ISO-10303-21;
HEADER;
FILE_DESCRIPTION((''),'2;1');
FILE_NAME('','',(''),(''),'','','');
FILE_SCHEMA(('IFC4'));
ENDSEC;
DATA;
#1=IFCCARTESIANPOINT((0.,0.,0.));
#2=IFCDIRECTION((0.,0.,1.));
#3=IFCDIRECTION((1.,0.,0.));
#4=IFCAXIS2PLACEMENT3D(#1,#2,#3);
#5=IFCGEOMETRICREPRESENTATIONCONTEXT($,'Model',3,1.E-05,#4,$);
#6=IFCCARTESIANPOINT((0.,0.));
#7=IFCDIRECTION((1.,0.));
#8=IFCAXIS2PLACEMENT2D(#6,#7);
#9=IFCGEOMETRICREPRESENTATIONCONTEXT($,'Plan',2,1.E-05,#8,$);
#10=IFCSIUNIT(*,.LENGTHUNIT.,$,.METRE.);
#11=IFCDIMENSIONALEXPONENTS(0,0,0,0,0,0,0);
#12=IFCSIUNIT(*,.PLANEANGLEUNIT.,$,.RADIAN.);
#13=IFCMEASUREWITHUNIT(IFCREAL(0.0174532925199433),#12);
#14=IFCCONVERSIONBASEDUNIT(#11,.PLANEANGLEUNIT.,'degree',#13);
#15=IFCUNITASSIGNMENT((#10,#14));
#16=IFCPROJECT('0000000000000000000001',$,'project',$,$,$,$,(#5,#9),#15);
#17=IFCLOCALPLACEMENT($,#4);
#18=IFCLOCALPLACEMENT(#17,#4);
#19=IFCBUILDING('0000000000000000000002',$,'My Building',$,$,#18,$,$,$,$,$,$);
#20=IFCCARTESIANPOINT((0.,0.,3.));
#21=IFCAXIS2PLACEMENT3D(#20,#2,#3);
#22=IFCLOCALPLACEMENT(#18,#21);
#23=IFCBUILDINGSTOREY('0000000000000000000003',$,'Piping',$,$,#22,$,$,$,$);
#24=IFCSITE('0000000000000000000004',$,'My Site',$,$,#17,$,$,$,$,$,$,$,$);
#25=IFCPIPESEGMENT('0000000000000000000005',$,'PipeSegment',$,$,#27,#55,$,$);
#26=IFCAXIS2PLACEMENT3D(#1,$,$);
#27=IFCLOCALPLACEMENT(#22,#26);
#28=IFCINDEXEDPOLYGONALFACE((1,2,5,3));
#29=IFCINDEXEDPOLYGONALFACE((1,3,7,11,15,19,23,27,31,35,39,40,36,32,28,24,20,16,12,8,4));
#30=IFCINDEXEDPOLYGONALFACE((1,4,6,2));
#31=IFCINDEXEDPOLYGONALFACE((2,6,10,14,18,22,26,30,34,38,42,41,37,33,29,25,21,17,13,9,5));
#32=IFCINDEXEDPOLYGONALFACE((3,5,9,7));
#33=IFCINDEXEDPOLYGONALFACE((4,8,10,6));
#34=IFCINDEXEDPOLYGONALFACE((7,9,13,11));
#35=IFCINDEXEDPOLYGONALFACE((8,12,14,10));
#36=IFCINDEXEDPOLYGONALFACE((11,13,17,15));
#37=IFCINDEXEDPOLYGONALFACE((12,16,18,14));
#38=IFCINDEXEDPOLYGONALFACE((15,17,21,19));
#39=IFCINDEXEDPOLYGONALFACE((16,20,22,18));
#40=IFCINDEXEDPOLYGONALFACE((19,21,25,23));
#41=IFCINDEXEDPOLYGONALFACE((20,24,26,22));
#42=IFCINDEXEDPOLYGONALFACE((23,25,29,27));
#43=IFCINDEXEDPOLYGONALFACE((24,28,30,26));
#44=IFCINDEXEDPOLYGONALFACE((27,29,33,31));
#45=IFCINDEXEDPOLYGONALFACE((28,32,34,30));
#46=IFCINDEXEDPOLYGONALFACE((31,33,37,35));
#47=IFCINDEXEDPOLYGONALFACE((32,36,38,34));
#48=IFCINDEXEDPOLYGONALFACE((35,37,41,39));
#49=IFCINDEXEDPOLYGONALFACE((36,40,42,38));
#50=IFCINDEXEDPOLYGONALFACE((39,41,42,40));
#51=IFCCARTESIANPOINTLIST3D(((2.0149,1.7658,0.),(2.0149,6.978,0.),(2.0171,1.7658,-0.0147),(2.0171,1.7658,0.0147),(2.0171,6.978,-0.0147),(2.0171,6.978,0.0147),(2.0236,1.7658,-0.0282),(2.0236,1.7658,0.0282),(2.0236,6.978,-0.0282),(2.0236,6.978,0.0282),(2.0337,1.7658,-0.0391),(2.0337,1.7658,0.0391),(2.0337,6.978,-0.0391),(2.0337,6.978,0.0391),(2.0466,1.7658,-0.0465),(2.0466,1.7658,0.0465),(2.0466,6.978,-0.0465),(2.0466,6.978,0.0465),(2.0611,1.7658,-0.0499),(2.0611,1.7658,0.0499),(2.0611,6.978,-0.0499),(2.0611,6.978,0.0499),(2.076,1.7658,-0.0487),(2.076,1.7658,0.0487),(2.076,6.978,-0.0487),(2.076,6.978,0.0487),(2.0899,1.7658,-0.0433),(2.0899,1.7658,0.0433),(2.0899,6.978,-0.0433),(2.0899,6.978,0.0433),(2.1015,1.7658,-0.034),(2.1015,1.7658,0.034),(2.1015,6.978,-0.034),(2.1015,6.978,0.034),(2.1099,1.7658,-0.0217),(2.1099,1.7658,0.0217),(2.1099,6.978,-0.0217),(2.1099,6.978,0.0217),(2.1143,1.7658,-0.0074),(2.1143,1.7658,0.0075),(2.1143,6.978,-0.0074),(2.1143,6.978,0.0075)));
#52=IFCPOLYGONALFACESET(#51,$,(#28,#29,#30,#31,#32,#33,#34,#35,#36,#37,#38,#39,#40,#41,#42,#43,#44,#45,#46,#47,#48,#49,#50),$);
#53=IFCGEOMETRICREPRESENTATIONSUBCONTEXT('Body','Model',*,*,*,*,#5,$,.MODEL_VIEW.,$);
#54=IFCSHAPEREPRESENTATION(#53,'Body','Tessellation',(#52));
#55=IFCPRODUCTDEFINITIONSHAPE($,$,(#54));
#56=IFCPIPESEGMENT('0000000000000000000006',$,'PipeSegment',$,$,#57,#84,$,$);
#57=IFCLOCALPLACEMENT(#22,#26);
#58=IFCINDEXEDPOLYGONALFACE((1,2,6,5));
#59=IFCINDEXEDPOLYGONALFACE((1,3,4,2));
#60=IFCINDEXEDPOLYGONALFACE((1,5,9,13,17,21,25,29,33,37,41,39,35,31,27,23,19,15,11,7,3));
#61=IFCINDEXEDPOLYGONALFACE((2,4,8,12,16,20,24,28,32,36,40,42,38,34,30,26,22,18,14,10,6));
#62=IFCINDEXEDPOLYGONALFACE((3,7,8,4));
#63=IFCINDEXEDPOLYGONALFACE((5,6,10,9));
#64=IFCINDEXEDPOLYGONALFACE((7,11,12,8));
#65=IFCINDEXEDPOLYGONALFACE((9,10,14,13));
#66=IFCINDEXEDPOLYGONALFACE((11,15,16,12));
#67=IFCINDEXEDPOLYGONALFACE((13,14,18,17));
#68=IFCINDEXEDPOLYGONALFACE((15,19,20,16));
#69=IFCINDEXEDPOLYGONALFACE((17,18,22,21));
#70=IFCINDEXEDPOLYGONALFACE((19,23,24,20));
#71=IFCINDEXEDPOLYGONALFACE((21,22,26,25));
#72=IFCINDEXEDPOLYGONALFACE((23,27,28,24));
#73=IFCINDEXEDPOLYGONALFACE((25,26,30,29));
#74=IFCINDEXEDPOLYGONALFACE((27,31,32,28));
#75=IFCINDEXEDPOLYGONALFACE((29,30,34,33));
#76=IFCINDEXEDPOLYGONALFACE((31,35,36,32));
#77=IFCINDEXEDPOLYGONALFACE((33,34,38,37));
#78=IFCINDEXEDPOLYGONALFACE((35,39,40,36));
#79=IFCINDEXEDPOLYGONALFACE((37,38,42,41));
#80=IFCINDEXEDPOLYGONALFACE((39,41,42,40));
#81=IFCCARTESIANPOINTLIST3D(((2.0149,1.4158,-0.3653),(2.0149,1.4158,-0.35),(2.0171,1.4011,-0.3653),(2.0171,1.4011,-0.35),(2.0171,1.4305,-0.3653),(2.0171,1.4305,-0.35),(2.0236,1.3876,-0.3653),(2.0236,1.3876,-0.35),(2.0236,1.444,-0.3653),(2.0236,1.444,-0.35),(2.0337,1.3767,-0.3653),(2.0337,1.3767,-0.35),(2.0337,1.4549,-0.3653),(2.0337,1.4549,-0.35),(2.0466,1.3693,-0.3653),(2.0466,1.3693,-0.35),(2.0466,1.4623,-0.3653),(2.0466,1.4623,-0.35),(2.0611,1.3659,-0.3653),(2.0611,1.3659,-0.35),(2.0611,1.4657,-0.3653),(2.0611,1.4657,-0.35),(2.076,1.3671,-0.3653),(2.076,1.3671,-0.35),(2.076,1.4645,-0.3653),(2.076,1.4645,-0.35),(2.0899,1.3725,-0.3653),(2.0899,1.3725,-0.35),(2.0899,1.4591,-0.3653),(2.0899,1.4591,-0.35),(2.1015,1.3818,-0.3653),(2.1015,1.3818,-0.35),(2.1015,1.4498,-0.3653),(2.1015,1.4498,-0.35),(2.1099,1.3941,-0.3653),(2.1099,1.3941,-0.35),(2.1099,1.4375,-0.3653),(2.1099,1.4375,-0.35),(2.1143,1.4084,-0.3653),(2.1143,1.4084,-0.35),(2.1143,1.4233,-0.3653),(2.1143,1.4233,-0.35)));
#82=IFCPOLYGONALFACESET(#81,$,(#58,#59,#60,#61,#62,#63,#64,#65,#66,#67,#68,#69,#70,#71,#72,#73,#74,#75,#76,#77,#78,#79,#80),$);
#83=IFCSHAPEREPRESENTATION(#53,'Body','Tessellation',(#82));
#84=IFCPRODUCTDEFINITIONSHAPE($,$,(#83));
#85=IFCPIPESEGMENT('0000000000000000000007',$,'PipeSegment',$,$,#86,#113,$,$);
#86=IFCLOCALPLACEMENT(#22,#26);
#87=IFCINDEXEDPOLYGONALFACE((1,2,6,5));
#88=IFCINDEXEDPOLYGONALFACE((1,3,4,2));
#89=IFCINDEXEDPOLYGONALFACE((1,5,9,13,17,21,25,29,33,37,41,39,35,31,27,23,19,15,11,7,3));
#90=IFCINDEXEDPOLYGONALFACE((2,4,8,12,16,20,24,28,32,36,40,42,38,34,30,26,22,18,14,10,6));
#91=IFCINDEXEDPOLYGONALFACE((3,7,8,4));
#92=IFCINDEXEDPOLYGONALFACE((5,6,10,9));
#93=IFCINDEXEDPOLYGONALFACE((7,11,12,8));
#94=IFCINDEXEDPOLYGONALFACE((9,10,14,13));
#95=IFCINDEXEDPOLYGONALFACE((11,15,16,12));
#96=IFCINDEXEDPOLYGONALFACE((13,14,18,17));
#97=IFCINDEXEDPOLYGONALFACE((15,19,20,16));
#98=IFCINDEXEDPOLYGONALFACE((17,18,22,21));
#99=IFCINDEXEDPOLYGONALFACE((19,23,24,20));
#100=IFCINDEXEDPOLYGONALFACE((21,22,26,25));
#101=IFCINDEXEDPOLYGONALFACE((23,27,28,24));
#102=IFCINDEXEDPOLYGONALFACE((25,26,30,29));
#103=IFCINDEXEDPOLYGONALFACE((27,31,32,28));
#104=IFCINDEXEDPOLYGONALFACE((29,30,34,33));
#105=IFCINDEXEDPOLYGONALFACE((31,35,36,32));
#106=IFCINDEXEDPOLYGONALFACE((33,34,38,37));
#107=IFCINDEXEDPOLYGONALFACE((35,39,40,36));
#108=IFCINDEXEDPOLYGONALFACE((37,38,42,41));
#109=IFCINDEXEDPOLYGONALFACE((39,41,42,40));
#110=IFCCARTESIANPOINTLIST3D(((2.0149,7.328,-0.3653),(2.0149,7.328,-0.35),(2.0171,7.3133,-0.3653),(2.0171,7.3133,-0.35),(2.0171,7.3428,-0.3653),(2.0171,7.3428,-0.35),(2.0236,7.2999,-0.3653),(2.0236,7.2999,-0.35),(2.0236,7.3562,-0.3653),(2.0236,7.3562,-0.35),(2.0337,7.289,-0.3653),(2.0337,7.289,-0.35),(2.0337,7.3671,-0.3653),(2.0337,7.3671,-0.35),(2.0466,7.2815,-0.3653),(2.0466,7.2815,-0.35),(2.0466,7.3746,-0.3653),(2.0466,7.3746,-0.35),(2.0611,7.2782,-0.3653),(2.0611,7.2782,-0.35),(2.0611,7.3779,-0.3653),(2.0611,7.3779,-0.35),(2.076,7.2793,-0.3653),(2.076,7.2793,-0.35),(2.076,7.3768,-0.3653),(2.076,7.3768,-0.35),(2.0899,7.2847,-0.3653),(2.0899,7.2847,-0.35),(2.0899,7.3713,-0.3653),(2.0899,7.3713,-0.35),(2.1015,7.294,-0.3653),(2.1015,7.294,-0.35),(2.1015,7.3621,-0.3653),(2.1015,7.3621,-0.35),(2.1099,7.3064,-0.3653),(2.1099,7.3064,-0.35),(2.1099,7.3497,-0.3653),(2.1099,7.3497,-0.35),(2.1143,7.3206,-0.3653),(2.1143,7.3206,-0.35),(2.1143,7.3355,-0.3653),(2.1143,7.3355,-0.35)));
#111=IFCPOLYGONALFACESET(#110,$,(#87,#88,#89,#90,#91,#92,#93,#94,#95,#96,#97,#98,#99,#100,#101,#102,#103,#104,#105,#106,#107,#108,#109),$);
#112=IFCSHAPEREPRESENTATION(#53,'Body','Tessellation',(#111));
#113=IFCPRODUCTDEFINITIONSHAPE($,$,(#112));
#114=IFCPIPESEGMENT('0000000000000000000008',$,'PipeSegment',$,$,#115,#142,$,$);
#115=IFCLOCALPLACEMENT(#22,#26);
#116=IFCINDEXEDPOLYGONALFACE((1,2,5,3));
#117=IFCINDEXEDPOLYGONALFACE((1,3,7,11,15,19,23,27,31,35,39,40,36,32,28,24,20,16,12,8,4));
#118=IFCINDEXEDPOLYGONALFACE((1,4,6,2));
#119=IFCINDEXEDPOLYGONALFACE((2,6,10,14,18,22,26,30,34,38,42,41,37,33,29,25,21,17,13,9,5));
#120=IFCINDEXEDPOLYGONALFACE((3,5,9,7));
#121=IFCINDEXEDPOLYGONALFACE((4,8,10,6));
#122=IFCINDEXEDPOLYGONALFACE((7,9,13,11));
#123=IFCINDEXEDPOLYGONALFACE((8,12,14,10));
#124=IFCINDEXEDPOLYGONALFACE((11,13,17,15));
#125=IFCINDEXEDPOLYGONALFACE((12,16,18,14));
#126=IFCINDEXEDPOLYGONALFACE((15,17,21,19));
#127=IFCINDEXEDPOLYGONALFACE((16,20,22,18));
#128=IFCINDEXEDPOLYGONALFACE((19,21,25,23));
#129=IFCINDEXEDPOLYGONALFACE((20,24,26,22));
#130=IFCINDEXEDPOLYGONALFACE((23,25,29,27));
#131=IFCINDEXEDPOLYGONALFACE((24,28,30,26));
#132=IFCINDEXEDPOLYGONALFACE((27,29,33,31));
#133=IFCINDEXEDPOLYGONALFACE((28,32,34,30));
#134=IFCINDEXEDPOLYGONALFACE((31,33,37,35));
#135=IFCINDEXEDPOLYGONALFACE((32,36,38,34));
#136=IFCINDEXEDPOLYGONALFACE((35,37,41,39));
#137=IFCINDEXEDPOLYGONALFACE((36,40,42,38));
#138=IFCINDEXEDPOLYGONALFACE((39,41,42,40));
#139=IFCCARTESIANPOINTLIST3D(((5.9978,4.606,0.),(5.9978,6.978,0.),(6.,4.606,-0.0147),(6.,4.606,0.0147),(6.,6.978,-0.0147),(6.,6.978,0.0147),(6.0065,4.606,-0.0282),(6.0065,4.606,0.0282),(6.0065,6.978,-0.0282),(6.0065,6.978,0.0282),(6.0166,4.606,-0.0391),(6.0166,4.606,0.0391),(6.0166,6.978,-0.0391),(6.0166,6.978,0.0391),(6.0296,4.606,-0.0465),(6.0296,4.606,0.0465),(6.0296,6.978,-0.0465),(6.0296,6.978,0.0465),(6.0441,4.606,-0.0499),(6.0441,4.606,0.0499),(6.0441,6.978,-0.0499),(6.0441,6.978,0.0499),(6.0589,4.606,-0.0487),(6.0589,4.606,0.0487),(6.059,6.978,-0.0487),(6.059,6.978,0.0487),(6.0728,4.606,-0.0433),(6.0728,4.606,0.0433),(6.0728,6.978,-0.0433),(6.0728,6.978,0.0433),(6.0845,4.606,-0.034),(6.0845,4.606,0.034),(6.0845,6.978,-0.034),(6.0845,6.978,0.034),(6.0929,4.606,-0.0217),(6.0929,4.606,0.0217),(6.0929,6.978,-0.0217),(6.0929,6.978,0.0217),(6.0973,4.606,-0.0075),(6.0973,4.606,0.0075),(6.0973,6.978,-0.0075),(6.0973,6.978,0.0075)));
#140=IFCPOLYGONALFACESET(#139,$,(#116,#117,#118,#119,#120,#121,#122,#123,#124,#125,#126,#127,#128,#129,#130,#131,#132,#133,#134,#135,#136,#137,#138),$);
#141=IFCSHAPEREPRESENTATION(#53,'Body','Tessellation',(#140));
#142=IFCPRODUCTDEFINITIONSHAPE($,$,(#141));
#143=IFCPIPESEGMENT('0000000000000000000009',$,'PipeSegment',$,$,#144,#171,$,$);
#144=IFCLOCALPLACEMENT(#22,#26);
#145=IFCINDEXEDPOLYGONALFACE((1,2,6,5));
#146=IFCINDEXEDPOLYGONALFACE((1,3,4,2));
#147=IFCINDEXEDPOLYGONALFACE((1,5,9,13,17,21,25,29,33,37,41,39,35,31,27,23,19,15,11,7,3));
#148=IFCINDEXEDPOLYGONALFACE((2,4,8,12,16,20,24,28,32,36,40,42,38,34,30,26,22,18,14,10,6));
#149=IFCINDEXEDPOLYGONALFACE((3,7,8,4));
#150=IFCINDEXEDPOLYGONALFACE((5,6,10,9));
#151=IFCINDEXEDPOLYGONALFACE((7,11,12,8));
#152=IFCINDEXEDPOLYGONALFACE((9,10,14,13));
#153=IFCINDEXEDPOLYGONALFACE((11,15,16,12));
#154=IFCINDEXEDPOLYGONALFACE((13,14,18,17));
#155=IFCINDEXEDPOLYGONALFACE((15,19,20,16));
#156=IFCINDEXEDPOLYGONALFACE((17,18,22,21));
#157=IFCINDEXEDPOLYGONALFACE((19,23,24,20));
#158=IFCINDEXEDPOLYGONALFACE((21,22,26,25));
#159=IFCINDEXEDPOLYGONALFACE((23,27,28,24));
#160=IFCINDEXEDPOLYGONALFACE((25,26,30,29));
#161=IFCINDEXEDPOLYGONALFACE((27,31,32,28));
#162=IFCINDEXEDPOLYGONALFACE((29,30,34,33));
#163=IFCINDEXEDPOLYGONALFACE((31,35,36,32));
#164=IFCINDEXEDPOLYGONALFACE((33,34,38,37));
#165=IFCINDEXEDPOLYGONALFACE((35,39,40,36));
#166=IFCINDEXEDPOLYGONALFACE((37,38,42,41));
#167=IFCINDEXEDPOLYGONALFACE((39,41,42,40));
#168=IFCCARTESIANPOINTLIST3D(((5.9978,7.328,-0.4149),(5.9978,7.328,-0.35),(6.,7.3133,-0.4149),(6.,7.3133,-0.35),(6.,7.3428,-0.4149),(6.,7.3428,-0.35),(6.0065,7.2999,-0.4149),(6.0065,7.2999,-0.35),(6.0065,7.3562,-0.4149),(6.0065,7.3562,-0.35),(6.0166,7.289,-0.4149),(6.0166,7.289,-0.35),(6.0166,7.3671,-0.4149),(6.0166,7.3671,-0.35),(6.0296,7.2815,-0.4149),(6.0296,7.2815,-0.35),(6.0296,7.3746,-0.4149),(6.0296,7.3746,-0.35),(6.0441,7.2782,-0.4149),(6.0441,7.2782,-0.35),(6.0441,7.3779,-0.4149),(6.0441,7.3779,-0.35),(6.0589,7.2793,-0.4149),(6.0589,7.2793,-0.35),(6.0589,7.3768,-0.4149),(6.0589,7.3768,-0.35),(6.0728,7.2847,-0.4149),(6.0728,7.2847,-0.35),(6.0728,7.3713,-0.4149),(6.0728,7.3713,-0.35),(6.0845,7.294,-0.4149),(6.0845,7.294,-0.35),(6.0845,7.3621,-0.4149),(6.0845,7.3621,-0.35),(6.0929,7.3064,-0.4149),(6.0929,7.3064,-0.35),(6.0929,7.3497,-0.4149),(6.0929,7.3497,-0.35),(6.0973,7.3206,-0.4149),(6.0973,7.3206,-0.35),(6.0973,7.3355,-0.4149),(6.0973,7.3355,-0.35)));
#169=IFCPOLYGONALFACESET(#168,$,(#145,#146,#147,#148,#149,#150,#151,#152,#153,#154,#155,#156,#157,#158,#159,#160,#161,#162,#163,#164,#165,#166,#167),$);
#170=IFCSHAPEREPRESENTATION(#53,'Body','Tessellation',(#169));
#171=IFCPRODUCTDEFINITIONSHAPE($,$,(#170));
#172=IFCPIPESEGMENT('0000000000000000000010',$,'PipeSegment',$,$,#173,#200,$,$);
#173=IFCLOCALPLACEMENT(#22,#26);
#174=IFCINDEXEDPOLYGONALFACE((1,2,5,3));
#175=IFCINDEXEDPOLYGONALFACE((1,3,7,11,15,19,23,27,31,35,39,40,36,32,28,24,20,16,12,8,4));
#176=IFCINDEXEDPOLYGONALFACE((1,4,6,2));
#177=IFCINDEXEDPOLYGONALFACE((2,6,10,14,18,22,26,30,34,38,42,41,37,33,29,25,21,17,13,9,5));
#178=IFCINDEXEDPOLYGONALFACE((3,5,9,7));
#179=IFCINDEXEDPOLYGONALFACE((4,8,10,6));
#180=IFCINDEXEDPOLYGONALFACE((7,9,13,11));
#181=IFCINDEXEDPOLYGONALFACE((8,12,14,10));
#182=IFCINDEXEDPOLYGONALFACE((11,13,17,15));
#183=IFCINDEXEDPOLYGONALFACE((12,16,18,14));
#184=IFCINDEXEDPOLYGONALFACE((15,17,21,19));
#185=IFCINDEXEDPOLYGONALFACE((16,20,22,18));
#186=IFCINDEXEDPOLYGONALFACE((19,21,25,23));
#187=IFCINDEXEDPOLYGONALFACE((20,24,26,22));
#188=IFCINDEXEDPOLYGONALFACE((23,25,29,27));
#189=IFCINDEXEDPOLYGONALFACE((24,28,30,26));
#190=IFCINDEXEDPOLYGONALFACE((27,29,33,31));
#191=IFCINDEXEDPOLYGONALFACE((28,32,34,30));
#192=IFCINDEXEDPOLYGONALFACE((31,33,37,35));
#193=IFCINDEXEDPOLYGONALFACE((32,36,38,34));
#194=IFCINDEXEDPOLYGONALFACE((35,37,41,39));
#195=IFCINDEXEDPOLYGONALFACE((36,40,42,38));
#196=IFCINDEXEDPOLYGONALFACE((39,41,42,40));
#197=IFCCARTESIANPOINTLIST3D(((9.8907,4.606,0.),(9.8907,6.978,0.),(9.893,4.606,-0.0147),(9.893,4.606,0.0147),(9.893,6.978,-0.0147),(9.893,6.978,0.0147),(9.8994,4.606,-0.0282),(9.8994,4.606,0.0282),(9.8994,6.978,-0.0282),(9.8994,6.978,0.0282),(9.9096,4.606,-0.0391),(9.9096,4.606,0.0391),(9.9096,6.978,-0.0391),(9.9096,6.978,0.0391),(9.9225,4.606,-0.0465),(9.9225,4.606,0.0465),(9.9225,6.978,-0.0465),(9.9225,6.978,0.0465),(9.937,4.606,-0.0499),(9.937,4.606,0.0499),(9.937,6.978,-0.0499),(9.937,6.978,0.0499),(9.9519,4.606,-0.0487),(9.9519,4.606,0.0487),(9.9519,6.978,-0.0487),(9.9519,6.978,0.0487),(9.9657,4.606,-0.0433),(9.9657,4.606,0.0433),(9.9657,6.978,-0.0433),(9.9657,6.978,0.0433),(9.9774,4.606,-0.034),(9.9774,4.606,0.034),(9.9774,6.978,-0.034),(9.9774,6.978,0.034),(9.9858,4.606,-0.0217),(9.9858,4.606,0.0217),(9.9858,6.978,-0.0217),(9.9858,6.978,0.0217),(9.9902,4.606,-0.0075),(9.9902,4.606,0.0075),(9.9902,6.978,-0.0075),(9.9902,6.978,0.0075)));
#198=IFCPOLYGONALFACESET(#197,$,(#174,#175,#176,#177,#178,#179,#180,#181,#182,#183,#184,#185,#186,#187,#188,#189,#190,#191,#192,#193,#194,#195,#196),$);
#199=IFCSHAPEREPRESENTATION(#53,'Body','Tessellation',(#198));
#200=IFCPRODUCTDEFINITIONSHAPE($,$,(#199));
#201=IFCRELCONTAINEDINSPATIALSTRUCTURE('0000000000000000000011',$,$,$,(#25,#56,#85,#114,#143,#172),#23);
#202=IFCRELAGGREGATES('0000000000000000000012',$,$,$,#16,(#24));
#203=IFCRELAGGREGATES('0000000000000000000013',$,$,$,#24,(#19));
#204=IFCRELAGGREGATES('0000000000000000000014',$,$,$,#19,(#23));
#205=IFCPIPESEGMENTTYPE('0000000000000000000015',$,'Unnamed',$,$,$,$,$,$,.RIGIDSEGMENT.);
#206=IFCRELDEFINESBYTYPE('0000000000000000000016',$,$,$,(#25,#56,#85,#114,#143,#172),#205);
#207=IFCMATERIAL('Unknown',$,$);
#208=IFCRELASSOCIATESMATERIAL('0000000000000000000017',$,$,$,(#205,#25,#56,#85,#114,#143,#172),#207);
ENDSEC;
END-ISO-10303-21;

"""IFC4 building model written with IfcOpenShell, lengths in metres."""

from ifc_helpers import new_model, entity, si_unit, converted_unit, frame, origin_with_axes, origin_2d_with_axis, place, context, subcontext, project, spatial, circle, extrude, material, material_profile, profile_set, profile_usage, type_object, element, save


model = new_model("IFC4")

# Units and contexts
model_context = context("Model", 3, precision=1e-05, world=origin_with_axes())
plan_context = context("Plan", 2, precision=1e-05, world=origin_2d_with_axis())
body_context = subcontext(model_context, "Body", "Model", "MODEL_VIEW")
ifc_project = project(units=[si_unit("LENGTHUNIT", "METRE"), converted_unit("PLANEANGLEUNIT", "degree", entity("IfcReal", 0.0174532925199433), si_unit("PLANEANGLEUNIT", "RADIAN"), dimensions=[0, 0, 0, 0, 0, 0, 0])], contexts=[model_context, plan_context])

# Site, building, storey
site_placement = place(None, origin_with_axes())
site = spatial("IfcSite", under=ifc_project, at=site_placement, Name="My Site")
building_placement = place(site_placement, origin_with_axes())
building = spatial("IfcBuilding", under=site, at=building_placement, Name="My Building")
storey_placement = place(building_placement, frame((0.0, 0.0, 3.0), z_axis=(0.0, 0.0, 1.0), x_axis=(1.0, 0.0, 0.0)))
storey = spatial("IfcBuildingStorey", under=building, at=storey_placement, Name="Piping")

# Pipe segments
ifc_material = material(Name="Unknown")
ifc_material_profile_1 = material_profile(ifc_material, circle(Radius=0.05))
ifc_profile_set_1 = profile_set([ifc_material_profile_1])
ifc_profile_usage_1 = profile_usage(ifc_profile_set_1, cardinal=5)
pipe_segment_type = type_object("IfcPipeSegmentType", Name="Unnamed", PredefinedType="RIGIDSEGMENT", material=ifc_profile_set_1)
pipe_segment_1_placement = place(storey_placement, frame((2.0649, 1.7658, 0.0), z_axis=(0.0, 1.0, 0.0), x_axis=(-1.0, 0.0, 0.0)))
element("IfcPipeSegment", 1, at=pipe_segment_1_placement, inside=storey, type_object=pipe_segment_type, material=ifc_profile_usage_1, Name="PipeSegment", context=body_context, shape_type="SweptSolid", body=[
    extrude(circle(Radius=0.05), origin_with_axes(), (0.0, 0.0, 1.0), 5.2122),
])
ifc_profile_usage_2 = profile_usage(ifc_profile_set_1, cardinal=5)
pipe_segment_2_placement = place(storey_placement, frame((2.0649, 1.4158, -0.35), z_axis=(0.0, 0.0, -1.0), x_axis=(-1.0, 0.0, 0.0)))
element("IfcPipeSegment", 2, at=pipe_segment_2_placement, inside=storey, type_object=pipe_segment_type, material=ifc_profile_usage_2, Name="PipeSegment", context=body_context, shape_type="SweptSolid", body=[
    extrude(circle(Radius=0.05), origin_with_axes(), (0.0, 0.0, 1.0), 0.0153),
])
ifc_profile_usage_3 = profile_usage(ifc_profile_set_1, cardinal=5)
pipe_segment_3_placement = place(storey_placement, frame((2.0649, 7.328, -0.35), z_axis=(0.0, 0.0, -1.0), x_axis=(-1.0, 0.0, 0.0)))
element("IfcPipeSegment", 3, at=pipe_segment_3_placement, inside=storey, type_object=pipe_segment_type, material=ifc_profile_usage_3, Name="PipeSegment", context=body_context, shape_type="SweptSolid", body=[
    extrude(circle(Radius=0.05), origin_with_axes(), (0.0, 0.0, 1.0), 0.0153),
])
ifc_profile_usage_4 = profile_usage(ifc_profile_set_1, cardinal=5)
pipe_segment_4_placement = place(storey_placement, frame((6.0478, 4.606, 0.0), z_axis=(0.0, 1.0, 0.0), x_axis=(-1.0, 0.0, 0.0)))
element("IfcPipeSegment", 4, at=pipe_segment_4_placement, inside=storey, type_object=pipe_segment_type, material=ifc_profile_usage_4, Name="PipeSegment", context=body_context, shape_type="SweptSolid", body=[
    extrude(circle(Radius=0.05), origin_with_axes(), (0.0, 0.0, 1.0), 2.372),
])
ifc_profile_usage_5 = profile_usage(ifc_profile_set_1, cardinal=5)
pipe_segment_5_placement = place(storey_placement, frame((6.0478, 7.328, -0.35), z_axis=(0.0, 0.0, -1.0), x_axis=(-1.0, 0.0, 0.0)))
element("IfcPipeSegment", 5, at=pipe_segment_5_placement, inside=storey, type_object=pipe_segment_type, material=ifc_profile_usage_5, Name="PipeSegment", context=body_context, shape_type="SweptSolid", body=[
    extrude(circle(Radius=0.05), origin_with_axes(), (0.0, 0.0, 1.0), 0.0649),
])
ifc_profile_usage_6 = profile_usage(ifc_profile_set_1, cardinal=5)
pipe_segment_6_placement = place(storey_placement, frame((9.9407, 4.606, 0.0), z_axis=(0.0, 1.0, 0.0), x_axis=(-1.0, 0.0, 0.0)))
element("IfcPipeSegment", 6, at=pipe_segment_6_placement, inside=storey, type_object=pipe_segment_type, material=ifc_profile_usage_6, Name="PipeSegment", context=body_context, shape_type="SweptSolid", body=[
    extrude(circle(Radius=0.05), origin_with_axes(), (0.0, 0.0, 1.0), 2.372),
])

save(model, "model.ifc")
